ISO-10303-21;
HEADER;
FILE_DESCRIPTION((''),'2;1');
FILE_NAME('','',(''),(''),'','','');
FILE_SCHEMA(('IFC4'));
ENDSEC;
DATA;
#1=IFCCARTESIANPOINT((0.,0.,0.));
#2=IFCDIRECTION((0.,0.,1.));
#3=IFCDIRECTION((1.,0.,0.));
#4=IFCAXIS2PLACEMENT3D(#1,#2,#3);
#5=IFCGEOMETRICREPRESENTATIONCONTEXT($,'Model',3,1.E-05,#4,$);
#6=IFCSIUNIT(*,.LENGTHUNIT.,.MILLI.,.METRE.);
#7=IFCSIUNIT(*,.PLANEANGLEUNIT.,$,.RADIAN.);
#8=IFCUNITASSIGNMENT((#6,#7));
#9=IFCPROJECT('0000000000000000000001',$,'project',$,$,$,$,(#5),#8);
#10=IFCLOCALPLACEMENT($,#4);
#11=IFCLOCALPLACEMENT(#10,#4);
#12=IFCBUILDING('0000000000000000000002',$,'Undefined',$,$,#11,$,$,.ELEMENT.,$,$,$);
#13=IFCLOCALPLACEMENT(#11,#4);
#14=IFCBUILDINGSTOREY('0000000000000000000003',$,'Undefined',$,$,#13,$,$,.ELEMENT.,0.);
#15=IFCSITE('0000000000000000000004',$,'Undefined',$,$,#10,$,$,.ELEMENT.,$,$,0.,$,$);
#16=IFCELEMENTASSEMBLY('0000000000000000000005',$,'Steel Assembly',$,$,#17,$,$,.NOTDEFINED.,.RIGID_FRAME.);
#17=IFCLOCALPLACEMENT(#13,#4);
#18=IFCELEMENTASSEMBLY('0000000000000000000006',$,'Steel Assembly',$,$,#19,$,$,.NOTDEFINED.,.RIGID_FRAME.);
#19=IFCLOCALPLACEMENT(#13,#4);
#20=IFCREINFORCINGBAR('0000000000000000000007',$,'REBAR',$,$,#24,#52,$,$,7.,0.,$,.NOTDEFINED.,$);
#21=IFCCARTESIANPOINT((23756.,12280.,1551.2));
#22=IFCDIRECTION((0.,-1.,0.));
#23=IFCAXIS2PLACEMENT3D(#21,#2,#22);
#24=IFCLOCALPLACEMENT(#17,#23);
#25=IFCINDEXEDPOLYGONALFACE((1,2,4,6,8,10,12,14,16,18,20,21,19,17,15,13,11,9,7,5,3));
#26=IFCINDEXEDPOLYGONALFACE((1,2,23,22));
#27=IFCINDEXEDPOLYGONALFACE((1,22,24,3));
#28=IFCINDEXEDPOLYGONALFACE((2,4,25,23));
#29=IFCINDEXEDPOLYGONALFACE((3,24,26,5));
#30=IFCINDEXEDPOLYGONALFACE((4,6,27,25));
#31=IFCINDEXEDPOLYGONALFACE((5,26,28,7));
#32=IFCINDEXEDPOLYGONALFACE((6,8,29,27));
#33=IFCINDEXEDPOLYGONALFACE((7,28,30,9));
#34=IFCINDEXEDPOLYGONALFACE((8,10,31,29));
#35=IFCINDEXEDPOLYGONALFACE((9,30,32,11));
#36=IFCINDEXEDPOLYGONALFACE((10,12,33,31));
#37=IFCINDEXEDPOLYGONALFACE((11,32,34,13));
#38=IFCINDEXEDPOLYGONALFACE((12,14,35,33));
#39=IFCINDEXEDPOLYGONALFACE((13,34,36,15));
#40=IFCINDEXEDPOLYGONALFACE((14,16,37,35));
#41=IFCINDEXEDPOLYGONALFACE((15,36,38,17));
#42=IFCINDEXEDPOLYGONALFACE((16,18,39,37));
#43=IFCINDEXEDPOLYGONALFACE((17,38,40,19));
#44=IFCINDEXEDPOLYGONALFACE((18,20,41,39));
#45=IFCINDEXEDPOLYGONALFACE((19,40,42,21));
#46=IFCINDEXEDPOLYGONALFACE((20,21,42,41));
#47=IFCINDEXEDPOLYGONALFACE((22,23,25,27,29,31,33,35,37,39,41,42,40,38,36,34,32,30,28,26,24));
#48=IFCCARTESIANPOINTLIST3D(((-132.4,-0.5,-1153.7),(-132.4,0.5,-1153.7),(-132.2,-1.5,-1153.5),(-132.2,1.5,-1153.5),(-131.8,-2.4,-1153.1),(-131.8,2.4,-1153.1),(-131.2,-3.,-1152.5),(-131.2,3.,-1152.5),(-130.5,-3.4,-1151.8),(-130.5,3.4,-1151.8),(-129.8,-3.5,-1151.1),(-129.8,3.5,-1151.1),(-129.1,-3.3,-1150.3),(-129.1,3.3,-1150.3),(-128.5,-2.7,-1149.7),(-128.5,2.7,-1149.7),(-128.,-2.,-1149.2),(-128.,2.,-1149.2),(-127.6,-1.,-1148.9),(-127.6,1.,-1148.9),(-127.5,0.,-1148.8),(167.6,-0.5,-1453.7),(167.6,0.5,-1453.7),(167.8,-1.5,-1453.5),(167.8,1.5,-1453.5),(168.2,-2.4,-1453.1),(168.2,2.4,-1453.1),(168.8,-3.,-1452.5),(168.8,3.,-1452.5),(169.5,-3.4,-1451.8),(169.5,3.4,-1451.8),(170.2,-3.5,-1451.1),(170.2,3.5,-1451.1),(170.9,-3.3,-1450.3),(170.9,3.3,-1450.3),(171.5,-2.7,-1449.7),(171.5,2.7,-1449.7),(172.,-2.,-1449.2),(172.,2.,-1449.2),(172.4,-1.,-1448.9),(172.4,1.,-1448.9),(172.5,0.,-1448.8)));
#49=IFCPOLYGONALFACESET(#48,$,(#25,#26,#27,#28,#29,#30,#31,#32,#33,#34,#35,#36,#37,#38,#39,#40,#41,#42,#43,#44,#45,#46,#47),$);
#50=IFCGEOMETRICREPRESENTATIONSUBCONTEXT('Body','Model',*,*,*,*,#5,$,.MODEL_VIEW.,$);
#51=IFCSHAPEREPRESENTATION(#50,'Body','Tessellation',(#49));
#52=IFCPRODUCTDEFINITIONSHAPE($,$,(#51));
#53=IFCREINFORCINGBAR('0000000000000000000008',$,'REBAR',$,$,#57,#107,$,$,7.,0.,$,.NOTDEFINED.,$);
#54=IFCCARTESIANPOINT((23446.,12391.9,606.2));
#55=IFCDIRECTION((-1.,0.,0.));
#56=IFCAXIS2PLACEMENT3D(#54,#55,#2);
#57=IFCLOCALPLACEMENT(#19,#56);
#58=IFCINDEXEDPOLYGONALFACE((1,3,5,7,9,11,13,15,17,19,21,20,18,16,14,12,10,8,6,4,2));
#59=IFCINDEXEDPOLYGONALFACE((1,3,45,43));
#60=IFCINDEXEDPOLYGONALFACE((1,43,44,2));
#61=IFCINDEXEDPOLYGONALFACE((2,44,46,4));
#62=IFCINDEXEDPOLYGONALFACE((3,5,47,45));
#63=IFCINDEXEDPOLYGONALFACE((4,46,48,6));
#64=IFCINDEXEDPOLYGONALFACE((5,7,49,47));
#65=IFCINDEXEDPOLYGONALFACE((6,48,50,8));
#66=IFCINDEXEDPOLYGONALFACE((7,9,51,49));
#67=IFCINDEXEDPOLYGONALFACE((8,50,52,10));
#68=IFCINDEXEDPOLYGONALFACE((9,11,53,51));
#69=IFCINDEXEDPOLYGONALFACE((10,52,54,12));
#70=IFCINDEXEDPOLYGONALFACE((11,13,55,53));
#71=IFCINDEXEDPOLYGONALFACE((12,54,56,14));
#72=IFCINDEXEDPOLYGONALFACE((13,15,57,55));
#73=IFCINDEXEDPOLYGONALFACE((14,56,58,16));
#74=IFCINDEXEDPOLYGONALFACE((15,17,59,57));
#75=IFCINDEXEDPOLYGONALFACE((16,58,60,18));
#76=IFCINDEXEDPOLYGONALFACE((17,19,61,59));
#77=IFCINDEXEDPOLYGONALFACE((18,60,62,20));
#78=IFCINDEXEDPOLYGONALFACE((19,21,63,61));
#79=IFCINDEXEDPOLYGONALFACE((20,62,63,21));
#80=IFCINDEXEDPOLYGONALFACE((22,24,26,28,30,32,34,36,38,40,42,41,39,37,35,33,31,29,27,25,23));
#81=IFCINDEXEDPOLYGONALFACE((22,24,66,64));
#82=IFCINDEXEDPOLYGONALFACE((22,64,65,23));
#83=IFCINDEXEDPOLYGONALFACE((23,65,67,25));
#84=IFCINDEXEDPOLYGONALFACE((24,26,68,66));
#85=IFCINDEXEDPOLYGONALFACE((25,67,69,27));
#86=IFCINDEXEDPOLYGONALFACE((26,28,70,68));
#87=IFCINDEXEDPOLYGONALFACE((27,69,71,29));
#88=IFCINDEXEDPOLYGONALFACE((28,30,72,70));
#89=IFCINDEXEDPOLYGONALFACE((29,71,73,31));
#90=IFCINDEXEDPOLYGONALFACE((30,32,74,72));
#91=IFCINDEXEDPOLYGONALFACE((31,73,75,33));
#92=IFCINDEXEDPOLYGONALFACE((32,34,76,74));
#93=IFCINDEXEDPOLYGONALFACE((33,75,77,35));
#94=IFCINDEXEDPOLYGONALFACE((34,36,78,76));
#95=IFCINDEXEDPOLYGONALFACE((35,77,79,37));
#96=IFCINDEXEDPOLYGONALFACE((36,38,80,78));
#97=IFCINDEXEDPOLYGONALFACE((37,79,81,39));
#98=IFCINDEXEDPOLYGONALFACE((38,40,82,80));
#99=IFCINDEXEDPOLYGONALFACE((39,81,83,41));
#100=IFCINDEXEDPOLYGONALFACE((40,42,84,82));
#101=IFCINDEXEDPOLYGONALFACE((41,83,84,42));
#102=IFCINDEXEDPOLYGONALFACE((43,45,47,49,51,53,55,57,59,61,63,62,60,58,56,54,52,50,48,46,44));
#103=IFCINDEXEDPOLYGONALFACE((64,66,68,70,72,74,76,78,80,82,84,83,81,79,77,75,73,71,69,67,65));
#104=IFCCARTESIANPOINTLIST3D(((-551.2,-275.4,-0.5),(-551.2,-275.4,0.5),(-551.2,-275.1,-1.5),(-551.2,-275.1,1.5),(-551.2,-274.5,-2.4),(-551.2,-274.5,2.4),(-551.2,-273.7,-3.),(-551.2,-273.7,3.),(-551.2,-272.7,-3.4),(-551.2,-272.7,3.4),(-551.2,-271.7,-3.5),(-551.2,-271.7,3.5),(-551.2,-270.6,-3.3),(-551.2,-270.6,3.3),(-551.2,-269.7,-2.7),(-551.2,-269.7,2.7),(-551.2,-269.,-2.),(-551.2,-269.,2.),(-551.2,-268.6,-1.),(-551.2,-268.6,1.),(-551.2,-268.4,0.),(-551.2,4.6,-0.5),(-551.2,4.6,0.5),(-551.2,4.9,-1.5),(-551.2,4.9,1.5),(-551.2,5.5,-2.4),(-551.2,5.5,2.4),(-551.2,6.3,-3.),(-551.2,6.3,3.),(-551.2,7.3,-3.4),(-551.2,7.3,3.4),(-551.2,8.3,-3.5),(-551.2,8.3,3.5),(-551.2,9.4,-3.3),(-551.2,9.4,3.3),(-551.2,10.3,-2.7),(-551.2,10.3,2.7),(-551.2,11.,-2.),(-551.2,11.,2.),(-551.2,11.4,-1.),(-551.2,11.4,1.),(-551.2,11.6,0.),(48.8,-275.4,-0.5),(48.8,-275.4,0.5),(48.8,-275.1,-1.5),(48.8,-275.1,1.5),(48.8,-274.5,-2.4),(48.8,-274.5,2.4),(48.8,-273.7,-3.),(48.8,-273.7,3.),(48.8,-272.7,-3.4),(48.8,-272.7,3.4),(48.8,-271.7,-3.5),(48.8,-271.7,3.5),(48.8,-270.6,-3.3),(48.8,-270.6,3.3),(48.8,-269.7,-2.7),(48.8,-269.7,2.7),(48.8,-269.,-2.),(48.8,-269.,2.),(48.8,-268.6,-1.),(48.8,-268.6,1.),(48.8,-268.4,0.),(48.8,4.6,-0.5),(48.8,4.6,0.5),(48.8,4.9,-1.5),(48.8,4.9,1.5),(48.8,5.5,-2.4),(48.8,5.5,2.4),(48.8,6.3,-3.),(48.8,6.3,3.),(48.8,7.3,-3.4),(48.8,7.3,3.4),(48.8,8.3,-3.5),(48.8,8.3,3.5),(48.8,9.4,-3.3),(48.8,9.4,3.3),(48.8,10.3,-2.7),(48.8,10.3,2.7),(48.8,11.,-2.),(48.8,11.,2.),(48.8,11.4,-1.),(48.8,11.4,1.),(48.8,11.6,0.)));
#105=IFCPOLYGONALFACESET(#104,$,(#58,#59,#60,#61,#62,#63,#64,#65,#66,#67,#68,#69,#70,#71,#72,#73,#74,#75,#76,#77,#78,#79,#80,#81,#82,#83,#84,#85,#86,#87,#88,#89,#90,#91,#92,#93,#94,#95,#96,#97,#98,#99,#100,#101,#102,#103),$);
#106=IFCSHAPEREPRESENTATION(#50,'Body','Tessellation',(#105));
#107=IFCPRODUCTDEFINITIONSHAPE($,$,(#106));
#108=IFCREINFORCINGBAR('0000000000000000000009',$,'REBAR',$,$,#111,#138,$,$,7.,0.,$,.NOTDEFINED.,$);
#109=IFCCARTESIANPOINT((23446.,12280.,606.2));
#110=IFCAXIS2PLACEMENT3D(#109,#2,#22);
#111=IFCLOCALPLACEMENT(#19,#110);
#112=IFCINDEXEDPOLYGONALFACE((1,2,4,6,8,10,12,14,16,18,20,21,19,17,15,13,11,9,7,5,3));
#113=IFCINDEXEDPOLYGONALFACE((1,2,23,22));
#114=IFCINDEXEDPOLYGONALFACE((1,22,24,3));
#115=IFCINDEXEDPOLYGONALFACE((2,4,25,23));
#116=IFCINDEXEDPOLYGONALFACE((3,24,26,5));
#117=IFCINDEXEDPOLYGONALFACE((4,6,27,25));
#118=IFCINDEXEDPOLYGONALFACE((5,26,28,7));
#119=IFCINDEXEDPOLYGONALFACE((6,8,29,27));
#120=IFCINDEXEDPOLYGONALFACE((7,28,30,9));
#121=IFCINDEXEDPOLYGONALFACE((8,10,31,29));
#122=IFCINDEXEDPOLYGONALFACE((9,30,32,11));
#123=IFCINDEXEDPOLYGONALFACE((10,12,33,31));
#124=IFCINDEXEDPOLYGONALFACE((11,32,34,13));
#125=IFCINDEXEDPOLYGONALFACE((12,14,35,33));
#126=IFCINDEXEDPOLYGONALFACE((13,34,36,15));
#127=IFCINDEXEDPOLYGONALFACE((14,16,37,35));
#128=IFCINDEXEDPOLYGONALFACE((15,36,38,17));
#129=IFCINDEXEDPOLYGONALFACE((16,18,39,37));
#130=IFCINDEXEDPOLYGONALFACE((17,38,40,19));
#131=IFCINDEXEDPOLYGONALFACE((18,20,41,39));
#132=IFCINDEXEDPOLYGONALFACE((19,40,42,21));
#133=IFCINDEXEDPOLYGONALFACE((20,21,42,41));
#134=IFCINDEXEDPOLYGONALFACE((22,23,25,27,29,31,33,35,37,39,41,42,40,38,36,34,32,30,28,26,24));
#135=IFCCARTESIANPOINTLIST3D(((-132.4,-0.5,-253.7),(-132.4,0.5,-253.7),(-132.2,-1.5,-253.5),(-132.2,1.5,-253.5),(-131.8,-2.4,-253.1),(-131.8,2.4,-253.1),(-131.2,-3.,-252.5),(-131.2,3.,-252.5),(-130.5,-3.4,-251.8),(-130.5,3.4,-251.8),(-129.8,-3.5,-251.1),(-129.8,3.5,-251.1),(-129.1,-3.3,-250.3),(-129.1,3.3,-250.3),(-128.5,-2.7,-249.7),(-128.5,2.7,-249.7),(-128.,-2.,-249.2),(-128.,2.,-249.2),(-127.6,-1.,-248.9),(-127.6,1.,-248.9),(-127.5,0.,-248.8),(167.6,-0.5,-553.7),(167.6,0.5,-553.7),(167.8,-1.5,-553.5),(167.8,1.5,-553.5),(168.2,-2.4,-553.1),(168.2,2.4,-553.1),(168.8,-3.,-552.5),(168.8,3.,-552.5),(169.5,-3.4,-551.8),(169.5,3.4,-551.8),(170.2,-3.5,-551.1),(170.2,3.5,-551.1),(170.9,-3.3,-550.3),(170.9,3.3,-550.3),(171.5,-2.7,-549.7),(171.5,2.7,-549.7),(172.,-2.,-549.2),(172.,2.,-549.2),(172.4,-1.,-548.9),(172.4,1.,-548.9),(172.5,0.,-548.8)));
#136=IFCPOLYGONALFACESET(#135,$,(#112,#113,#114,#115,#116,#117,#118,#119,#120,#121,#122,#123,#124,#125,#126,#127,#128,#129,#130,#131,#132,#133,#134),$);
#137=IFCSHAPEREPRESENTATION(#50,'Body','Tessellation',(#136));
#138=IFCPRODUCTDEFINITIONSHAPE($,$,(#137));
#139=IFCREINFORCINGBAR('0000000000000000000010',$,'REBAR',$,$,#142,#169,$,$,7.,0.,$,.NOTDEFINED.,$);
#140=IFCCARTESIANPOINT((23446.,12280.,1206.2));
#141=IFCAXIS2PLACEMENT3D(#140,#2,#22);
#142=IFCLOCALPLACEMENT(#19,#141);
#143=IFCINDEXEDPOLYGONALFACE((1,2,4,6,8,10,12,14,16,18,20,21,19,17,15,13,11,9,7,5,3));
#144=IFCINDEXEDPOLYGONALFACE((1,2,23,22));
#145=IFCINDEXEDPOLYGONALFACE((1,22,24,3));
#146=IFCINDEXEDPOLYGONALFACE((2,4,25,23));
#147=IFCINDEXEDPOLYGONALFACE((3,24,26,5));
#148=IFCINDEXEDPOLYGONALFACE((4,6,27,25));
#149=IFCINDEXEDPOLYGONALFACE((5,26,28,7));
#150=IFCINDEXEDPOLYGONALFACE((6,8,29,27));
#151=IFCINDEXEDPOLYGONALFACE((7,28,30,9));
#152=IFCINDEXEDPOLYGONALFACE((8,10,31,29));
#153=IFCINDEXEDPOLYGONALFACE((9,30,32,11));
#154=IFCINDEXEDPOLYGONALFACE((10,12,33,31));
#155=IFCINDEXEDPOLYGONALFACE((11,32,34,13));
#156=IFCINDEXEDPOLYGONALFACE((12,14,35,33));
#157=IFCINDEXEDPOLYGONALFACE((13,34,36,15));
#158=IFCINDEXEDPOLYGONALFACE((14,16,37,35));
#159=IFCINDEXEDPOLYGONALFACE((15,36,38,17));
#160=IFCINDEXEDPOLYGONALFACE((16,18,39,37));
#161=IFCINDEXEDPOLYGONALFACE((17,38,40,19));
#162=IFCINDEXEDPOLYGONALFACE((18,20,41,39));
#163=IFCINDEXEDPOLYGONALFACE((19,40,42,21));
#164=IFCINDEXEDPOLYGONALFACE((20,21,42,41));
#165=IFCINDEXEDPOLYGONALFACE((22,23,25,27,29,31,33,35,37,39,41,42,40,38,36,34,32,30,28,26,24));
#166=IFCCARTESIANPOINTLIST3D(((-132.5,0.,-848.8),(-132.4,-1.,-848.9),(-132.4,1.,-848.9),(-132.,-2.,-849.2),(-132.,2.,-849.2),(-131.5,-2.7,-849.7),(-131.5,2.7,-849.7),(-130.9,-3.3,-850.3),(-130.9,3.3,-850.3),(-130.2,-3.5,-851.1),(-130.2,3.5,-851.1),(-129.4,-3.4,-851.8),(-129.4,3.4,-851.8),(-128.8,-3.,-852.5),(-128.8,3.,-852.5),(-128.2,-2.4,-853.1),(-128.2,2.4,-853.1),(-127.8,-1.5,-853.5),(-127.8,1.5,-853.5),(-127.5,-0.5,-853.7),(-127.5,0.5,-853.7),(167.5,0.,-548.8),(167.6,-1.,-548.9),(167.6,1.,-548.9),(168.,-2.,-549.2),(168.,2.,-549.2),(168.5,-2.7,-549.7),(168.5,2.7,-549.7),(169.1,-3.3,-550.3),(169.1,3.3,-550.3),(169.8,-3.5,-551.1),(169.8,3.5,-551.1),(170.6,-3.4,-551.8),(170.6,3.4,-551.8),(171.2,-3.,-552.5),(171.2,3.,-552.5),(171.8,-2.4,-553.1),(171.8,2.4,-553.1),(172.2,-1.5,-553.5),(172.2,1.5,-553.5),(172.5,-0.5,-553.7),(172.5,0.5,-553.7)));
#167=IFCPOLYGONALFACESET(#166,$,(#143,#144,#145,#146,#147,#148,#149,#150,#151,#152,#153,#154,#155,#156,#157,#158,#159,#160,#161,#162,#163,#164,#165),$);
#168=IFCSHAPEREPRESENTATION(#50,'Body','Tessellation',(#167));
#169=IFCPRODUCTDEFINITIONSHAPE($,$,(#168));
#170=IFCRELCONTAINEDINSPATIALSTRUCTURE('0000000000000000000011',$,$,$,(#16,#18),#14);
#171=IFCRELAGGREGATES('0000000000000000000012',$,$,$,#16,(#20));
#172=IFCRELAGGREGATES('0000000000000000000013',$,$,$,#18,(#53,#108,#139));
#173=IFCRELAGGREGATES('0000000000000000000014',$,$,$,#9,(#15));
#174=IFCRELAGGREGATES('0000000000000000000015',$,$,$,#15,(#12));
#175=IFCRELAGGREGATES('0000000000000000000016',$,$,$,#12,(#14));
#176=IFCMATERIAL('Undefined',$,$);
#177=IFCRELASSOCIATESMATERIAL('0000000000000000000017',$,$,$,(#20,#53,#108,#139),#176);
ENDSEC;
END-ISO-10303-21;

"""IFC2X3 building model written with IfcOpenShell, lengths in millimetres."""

from ifc_helpers import new_model, entity, si_unit, frame, origin_with_axes, place, context, subcontext, project, spatial, source, transform, mapped, material, element, aggregate, save


model = new_model("IFC2X3")

# Units and contexts
model_context = context("Model", 3, precision=1e-05, world=origin_with_axes())
body_context = subcontext(model_context, "Body", "Model", "MODEL_VIEW")
ifc_project = project(units=[si_unit("LENGTHUNIT", "METRE", prefix="MILLI"), si_unit("PLANEANGLEUNIT", "RADIAN")], contexts=[model_context])

# Site, building, storey
site_placement = place(None, origin_with_axes())
site = spatial("IfcSite", under=ifc_project, at=site_placement, Name="Undefined", CompositionType="ELEMENT", RefElevation=0.0)
building_placement = place(site_placement, origin_with_axes())
building = spatial("IfcBuilding", under=site, at=building_placement, Name="Undefined", CompositionType="ELEMENT")
storey_placement = place(building_placement, origin_with_axes())
storey = spatial("IfcBuildingStorey", under=building, at=storey_placement, Name="Undefined", CompositionType="ELEMENT", Elevation=0.0)

# Element assemblies
assembly_1_placement = place(storey_placement, origin_with_axes())
assembly_1 = element("IfcElementAssembly", 1, at=assembly_1_placement, inside=storey, Name="Steel Assembly", AssemblyPlace="NOTDEFINED", PredefinedType="RIGID_FRAME")
assembly_2_placement = place(storey_placement, origin_with_axes())
assembly_2 = element("IfcElementAssembly", 2, at=assembly_2_placement, inside=storey, Name="Steel Assembly", AssemblyPlace="NOTDEFINED", PredefinedType="RIGID_FRAME")

# Shared definitions
ifc_material_1 = material(Name="Undefined")

# Reinforcing bars
shared_shape_1 = source(origin_with_axes(), body_context, "Body", "AdvancedSweptSolid", [
    entity("IfcSweptDiskSolid", entity("IfcTrimmedCurve", entity("IfcLine", entity("IfcCartesianPoint", [0.0, 0.0, 0.0]), entity("IfcVector", entity("IfcDirection", [0.707107, 0.0, -0.707107]), 1.0)), [entity("IfcParameterValue", 0.0)], [entity("IfcParameterValue", 424.264069)], True, "PARAMETER"), 3.5, None, 0.0, 424.3),
])
reinforcing_bar_1_placement = place(assembly_1_placement, frame((23756.0, 12280.0, 1551.2), z_axis=(0.0, 0.0, 1.0), x_axis=(0.0, -1.0, 0.0)))
reinforcing_bar_1 = element("IfcReinforcingBar", 3, at=reinforcing_bar_1_placement, material=ifc_material_1, Name="REBAR", BarRole="NOTDEFINED", CrossSectionArea=0.0, NominalDiameter=7.0, context=body_context, shape_type="MappedRepresentation", body=[
    mapped(shared_shape_1, transform((-130.0, 0.0, -1151.2))),
])
aggregate(assembly_1, [reinforcing_bar_1])
shared_shape_2 = source(origin_with_axes(), body_context, "Body", "AdvancedSweptSolid", [
    entity("IfcSweptDiskSolid", entity("IfcTrimmedCurve", entity("IfcLine", entity("IfcCartesianPoint", [0.0, 0.0, 0.0]), entity("IfcVector", entity("IfcDirection", [1.0, 0.00001, 0.0]), 1.0)), [entity("IfcParameterValue", 0.0)], [entity("IfcParameterValue", 600.0)], True, "PARAMETER"), 3.5, None, 0.0, 600.0),
])
shared_shape_3 = source(origin_with_axes(), body_context, "Body", "AdvancedSweptSolid", [
    entity("IfcSweptDiskSolid", entity("IfcTrimmedCurve", entity("IfcLine", entity("IfcCartesianPoint", [0.0, 0.0, 0.0]), entity("IfcVector", entity("IfcDirection", [1.0, 0.00001, 0.0]), 1.0)), [entity("IfcParameterValue", 0.0)], [entity("IfcParameterValue", 600.0)], True, "PARAMETER"), 3.5, None, 0.0, 600.0),
])
reinforcing_bar_2_placement = place(assembly_2_placement, frame((23446.0, 12391.9, 606.2), z_axis=(-1.0, 0.0, 0.0), x_axis=(0.0, 0.0, 1.0)))
reinforcing_bar_2 = element("IfcReinforcingBar", 4, at=reinforcing_bar_2_placement, material=ifc_material_1, Name="REBAR", BarRole="NOTDEFINED", CrossSectionArea=0.0, NominalDiameter=7.0, context=body_context, shape_type="MappedRepresentation", body=[
    mapped(shared_shape_2, transform((-551.2, -271.9, 0.0))),
    mapped(shared_shape_3, transform((-551.2, 8.1, 0.0))),
])
shared_shape_4 = source(origin_with_axes(), body_context, "Body", "AdvancedSweptSolid", [
    entity("IfcSweptDiskSolid", entity("IfcTrimmedCurve", entity("IfcLine", entity("IfcCartesianPoint", [0.0, 0.0, 0.0]), entity("IfcVector", entity("IfcDirection", [0.707107, 0.0, -0.707107]), 1.0)), [entity("IfcParameterValue", 0.0)], [entity("IfcParameterValue", 424.264069)], True, "PARAMETER"), 3.5, None, 0.0, 424.3),
])
reinforcing_bar_3_placement = place(assembly_2_placement, frame((23446.0, 12280.0, 606.2), z_axis=(0.0, 0.0, 1.0), x_axis=(0.0, -1.0, 0.0)))
reinforcing_bar_3 = element("IfcReinforcingBar", 5, at=reinforcing_bar_3_placement, material=ifc_material_1, Name="REBAR", BarRole="NOTDEFINED", CrossSectionArea=0.0, NominalDiameter=7.0, context=body_context, shape_type="MappedRepresentation", body=[
    mapped(shared_shape_4, transform((-130.0, 0.0, -251.2))),
])
shared_shape_5 = source(origin_with_axes(), body_context, "Body", "AdvancedSweptSolid", [
    entity("IfcSweptDiskSolid", entity("IfcTrimmedCurve", entity("IfcLine", entity("IfcCartesianPoint", [0.0, 0.0, 0.0]), entity("IfcVector", entity("IfcDirection", [0.707107, 0.0, 0.707107]), 1.0)), [entity("IfcParameterValue", 0.0)], [entity("IfcParameterValue", 424.264069)], True, "PARAMETER"), 3.5, None, 0.0, 424.3),
])
reinforcing_bar_4_placement = place(assembly_2_placement, frame((23446.0, 12280.0, 1206.2), z_axis=(0.0, 0.0, 1.0), x_axis=(0.0, -1.0, 0.0)))
reinforcing_bar_4 = element("IfcReinforcingBar", 6, at=reinforcing_bar_4_placement, material=ifc_material_1, Name="REBAR", BarRole="NOTDEFINED", CrossSectionArea=0.0, NominalDiameter=7.0, context=body_context, shape_type="MappedRepresentation", body=[
    mapped(shared_shape_5, transform((-130.0, 0.0, -851.2))),
])
aggregate(assembly_2, [reinforcing_bar_2, reinforcing_bar_3, reinforcing_bar_4])

save(model, "model.ifc")
